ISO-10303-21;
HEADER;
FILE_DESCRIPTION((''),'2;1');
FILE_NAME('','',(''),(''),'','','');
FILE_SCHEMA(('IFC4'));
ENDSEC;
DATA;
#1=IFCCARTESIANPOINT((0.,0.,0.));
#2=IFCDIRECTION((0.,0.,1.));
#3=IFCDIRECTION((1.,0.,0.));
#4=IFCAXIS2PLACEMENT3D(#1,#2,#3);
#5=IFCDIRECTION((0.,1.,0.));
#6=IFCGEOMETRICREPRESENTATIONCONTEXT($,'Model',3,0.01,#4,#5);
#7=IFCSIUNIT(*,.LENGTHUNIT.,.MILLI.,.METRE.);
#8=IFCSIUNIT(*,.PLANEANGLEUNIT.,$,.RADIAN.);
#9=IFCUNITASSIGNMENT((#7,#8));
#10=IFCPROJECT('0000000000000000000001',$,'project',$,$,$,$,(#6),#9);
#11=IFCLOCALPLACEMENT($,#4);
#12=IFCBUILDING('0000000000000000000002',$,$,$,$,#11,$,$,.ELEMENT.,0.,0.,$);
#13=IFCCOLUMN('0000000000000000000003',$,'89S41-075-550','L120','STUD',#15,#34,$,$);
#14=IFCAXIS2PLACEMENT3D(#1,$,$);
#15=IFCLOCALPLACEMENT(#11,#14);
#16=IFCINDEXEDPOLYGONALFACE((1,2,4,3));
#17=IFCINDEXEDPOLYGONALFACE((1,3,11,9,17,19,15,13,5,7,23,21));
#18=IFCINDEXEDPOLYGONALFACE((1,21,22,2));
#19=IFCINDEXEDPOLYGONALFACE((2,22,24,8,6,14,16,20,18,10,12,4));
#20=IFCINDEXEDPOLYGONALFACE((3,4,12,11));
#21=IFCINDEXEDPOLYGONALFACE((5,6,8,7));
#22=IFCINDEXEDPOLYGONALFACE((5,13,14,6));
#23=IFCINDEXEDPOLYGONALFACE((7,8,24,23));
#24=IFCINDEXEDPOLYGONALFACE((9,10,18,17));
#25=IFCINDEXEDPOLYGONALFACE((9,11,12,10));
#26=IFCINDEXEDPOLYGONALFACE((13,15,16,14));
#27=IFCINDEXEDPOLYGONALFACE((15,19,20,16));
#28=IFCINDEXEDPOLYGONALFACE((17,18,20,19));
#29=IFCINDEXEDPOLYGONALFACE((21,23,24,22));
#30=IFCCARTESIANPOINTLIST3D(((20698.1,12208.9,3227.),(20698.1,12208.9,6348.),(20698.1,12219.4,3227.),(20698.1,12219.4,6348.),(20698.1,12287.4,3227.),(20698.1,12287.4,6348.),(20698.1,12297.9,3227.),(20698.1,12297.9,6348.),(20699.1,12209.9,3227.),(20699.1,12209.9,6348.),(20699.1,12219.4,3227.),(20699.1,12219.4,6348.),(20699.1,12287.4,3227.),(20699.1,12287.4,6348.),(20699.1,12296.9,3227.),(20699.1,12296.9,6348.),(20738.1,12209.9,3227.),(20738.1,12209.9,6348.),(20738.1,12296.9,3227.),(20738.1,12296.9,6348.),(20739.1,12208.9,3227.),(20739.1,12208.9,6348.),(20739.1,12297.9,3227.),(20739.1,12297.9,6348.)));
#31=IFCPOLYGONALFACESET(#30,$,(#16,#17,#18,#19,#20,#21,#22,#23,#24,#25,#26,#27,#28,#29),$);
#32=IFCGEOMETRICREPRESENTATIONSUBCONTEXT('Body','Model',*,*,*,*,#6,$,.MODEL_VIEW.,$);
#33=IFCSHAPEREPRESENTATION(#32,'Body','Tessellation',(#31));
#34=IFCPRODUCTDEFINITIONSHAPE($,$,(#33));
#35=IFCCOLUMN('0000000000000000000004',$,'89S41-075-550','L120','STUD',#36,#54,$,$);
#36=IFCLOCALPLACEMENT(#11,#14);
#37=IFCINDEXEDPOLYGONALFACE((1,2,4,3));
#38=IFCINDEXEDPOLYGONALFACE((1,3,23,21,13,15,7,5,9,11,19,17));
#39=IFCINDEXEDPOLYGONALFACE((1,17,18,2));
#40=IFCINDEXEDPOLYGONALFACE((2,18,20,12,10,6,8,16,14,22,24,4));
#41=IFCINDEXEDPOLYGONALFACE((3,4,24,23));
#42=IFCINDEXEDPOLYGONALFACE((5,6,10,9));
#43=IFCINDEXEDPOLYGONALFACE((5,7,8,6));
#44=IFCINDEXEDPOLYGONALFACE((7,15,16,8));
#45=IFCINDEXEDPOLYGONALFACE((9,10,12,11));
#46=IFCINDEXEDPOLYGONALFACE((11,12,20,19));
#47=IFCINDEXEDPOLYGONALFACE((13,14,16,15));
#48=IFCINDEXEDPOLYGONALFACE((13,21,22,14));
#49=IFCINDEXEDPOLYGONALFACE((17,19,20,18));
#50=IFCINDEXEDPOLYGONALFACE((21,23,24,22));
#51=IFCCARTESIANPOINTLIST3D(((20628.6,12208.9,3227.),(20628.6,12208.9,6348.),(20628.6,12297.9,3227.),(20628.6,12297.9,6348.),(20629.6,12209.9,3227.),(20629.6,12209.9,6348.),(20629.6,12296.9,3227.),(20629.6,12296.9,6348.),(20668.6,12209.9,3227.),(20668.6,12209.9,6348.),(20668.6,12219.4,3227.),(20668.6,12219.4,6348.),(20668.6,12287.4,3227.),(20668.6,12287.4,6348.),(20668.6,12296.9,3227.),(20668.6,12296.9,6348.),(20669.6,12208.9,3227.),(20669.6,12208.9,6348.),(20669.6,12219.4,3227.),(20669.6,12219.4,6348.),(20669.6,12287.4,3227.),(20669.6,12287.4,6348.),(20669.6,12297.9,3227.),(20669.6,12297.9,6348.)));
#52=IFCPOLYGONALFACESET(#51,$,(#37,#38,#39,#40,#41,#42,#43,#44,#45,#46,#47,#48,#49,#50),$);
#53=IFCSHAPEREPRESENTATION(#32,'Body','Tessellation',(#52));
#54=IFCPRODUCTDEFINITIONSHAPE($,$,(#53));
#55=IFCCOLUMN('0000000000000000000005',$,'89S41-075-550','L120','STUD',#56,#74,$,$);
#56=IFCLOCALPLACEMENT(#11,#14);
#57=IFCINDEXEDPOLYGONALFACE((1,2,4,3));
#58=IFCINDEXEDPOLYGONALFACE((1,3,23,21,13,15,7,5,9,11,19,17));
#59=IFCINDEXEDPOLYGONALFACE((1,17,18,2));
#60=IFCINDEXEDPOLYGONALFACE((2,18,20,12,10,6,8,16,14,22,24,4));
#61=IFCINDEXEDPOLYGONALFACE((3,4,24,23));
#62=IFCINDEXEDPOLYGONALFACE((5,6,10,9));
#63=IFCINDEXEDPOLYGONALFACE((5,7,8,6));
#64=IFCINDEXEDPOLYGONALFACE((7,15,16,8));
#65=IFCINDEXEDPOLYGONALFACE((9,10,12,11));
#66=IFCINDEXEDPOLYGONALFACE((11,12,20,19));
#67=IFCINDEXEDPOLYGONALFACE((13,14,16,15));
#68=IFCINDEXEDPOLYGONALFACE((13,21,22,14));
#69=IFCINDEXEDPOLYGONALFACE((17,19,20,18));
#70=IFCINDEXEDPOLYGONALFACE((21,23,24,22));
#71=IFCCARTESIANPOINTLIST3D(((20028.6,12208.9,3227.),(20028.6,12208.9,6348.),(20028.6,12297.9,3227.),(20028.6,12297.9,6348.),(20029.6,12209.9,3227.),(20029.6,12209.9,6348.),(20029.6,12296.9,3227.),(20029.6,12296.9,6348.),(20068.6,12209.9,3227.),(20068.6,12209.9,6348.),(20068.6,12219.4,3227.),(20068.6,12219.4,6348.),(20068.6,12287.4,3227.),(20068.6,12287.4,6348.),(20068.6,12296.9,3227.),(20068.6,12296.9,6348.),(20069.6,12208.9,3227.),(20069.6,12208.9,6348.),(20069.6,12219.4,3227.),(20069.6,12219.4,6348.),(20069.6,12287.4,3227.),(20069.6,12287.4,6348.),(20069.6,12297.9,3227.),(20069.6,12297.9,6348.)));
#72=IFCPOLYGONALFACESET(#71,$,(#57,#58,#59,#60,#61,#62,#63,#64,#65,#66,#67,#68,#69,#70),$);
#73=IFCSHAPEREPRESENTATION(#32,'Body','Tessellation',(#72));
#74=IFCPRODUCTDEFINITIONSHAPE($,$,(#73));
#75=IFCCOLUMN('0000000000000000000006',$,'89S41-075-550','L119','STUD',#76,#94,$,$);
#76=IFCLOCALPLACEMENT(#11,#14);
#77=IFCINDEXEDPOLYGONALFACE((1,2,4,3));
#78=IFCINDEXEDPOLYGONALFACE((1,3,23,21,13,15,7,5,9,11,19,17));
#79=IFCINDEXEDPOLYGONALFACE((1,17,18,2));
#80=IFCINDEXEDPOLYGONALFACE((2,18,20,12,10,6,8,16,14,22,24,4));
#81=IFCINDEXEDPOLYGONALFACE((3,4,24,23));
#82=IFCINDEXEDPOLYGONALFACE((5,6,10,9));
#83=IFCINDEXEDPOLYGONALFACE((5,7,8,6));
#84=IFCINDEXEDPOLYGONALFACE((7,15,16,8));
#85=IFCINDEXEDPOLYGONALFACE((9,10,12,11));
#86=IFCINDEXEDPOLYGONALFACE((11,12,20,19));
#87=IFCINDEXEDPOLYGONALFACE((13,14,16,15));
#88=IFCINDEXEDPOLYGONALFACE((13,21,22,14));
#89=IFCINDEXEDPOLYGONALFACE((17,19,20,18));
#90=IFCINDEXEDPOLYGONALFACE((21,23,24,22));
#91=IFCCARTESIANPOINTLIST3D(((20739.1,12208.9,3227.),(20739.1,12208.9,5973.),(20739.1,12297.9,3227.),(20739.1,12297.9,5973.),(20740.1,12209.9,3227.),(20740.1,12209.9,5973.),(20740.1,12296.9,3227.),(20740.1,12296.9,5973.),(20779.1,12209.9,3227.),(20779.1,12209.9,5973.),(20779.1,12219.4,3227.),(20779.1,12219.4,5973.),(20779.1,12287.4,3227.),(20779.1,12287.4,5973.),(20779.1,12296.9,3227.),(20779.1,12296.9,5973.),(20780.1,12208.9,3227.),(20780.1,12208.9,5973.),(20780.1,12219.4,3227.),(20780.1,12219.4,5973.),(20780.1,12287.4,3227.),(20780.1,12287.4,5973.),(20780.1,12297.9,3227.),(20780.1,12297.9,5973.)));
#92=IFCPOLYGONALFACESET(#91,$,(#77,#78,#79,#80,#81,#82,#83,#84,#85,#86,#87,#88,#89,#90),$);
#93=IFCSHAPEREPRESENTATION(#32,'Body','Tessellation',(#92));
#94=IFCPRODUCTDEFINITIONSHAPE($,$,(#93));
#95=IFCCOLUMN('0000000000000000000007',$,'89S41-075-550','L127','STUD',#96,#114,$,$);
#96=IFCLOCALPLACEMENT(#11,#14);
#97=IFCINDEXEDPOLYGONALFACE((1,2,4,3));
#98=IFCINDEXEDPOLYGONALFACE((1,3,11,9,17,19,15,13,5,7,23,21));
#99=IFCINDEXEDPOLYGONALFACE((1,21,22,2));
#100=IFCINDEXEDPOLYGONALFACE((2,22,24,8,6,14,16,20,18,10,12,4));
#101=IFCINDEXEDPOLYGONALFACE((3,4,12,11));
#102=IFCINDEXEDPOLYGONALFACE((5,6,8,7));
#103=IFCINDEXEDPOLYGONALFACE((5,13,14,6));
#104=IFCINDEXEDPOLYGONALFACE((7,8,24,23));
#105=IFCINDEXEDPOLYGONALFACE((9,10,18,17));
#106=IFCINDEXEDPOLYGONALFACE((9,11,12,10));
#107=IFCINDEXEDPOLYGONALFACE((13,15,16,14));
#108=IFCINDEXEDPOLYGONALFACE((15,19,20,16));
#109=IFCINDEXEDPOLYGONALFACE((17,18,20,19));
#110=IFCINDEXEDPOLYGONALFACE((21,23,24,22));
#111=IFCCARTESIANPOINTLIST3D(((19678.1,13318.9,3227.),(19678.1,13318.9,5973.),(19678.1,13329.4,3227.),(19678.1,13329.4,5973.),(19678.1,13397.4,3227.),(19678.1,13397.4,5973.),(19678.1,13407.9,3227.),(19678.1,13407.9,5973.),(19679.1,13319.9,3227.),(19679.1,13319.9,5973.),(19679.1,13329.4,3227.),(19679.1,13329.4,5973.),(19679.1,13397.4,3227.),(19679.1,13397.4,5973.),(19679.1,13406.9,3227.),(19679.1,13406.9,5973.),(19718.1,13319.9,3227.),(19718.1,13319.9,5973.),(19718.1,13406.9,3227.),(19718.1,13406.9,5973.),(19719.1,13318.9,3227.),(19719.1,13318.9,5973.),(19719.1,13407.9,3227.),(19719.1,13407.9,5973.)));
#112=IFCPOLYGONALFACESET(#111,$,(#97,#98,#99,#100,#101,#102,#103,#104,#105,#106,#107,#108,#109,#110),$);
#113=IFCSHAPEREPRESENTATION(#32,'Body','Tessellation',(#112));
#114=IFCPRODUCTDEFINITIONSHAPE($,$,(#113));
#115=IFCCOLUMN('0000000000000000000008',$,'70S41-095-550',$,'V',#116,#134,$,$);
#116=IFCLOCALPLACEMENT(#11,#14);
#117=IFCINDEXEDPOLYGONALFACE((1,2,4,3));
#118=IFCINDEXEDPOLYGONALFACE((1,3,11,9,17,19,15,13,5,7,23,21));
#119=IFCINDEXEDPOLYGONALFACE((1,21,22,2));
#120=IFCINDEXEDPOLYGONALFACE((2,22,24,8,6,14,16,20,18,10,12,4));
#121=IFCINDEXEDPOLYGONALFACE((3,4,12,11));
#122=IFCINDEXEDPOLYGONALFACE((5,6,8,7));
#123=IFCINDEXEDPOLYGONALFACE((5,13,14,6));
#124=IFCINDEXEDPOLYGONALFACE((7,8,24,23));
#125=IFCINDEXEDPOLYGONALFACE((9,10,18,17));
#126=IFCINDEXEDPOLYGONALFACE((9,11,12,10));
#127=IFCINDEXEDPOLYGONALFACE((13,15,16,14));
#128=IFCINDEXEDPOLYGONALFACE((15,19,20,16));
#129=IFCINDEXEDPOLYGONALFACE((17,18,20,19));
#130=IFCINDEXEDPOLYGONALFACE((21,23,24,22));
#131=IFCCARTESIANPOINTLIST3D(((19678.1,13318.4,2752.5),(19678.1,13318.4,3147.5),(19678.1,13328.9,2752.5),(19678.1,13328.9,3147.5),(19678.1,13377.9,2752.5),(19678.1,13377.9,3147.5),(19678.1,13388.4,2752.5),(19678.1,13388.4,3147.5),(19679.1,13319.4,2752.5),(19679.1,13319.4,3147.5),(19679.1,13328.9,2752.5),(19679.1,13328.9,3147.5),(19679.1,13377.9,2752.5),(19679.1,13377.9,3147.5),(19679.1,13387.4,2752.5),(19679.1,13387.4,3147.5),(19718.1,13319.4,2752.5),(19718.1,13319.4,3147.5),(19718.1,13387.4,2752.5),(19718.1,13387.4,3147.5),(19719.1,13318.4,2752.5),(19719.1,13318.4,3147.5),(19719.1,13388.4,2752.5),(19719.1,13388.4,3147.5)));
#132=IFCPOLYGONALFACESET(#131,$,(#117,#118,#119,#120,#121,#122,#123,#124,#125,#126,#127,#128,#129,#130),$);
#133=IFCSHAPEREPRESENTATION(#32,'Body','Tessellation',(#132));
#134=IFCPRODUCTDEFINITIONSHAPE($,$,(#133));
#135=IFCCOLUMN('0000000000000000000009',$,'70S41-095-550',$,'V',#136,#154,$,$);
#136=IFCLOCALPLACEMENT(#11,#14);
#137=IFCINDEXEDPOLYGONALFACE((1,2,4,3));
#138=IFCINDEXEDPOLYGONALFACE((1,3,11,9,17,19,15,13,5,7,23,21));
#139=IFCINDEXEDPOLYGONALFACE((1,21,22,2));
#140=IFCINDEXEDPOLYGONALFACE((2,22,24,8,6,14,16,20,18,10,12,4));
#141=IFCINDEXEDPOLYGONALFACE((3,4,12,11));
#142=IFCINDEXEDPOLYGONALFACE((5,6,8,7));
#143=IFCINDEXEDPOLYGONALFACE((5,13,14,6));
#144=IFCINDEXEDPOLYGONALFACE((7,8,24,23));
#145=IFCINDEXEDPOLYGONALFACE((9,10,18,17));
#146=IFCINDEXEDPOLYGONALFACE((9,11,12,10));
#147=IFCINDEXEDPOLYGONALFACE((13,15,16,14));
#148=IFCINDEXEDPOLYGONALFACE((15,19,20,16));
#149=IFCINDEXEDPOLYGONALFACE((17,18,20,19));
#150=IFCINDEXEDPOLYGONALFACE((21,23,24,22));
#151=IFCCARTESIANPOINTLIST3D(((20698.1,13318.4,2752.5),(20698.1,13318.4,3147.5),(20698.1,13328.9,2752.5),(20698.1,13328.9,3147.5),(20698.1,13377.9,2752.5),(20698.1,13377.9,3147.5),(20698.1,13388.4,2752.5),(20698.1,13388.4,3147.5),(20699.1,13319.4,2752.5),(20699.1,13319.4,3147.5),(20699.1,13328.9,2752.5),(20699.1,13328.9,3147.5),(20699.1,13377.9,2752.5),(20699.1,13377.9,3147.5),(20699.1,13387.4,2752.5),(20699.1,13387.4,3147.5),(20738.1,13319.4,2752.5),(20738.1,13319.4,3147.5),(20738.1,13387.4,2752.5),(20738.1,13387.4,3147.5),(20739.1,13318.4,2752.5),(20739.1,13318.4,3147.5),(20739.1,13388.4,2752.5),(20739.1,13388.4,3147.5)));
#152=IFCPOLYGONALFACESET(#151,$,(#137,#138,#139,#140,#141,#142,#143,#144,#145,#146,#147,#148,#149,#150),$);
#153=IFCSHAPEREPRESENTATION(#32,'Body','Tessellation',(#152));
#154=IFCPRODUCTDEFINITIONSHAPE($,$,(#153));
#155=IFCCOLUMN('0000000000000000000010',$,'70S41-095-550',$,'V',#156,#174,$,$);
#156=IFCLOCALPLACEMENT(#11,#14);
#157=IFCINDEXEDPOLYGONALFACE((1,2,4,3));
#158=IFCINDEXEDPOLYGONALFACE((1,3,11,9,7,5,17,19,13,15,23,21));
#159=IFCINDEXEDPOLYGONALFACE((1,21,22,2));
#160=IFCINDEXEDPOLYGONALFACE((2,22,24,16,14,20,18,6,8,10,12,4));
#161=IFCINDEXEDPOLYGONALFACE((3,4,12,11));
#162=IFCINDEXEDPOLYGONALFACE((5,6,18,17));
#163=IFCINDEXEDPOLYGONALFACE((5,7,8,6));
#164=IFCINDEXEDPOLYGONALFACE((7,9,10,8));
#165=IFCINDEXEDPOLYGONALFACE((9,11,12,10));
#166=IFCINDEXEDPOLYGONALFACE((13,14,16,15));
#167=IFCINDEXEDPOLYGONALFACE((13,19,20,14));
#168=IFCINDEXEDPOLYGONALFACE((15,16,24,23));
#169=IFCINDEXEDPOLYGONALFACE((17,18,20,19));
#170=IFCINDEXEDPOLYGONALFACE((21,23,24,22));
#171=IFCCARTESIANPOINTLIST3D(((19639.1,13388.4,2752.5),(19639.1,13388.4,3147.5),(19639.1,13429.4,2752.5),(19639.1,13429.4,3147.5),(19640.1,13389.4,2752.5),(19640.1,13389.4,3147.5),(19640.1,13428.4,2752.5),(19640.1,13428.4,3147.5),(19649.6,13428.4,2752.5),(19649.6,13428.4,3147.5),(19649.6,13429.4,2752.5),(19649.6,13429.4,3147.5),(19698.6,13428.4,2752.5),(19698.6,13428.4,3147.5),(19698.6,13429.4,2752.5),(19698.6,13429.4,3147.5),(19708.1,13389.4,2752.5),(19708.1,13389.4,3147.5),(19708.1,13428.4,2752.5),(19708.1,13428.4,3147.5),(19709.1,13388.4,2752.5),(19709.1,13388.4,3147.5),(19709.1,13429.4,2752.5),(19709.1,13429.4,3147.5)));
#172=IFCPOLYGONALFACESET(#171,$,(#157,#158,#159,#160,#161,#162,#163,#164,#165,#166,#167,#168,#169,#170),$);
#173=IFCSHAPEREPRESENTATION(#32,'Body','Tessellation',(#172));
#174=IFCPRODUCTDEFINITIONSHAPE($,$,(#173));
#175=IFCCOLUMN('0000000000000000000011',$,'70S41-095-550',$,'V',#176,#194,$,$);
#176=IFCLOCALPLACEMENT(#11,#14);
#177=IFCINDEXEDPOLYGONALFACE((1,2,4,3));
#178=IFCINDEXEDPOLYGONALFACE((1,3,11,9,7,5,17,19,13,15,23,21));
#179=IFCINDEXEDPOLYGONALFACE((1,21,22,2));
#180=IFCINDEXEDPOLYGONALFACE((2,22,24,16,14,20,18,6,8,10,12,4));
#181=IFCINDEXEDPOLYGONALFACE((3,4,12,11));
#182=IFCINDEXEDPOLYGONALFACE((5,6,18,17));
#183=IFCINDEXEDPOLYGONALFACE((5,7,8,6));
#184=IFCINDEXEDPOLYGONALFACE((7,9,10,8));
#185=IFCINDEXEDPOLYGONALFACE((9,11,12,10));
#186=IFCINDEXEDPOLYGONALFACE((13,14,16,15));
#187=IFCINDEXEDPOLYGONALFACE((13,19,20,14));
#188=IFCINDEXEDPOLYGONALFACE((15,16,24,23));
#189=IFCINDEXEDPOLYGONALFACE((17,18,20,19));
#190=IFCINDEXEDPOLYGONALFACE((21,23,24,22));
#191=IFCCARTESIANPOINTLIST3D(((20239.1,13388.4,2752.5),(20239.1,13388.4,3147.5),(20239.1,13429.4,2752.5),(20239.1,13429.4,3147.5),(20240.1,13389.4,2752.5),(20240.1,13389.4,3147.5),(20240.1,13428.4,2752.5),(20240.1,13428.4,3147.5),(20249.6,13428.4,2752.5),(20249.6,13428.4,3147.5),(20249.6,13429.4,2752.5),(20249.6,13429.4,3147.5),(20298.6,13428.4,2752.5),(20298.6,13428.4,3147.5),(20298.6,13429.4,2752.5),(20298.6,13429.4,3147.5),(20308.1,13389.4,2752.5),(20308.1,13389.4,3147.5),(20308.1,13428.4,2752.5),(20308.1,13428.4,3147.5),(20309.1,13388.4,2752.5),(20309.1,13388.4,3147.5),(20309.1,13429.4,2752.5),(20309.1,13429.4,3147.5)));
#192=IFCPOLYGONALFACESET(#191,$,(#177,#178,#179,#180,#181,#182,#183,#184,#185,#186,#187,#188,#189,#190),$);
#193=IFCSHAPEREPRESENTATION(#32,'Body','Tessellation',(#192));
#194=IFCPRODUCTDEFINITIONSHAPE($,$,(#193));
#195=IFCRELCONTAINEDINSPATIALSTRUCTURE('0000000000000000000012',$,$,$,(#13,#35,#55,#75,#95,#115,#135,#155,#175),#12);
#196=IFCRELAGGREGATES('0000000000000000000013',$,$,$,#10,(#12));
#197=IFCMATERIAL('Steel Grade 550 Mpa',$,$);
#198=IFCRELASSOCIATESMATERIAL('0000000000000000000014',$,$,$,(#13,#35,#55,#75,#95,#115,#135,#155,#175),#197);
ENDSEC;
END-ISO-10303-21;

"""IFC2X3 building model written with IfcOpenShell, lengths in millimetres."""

from ifc_helpers import new_model, si_unit, direction, frame, origin, origin_with_axes, origin_2d_with_axis, place, context, subcontext, project, spatial, c_section, extrude, source, transform, mapped, material, element, save


model = new_model("IFC2X3")

# Units and contexts
model_context = context("Model", 3, precision=0.01, world=origin_with_axes(), true_north=direction((0.0, 1.0, 0.0)))
body_context = subcontext(model_context, "Body", "Model", "MODEL_VIEW")
ifc_project = project(units=[si_unit("LENGTHUNIT", "METRE", prefix="MILLI"), si_unit("PLANEANGLEUNIT", "RADIAN")], contexts=[model_context])

# Building
building_placement = place(None, origin_with_axes())
building = spatial("IfcBuilding", under=ifc_project, at=building_placement, CompositionType="ELEMENT", ElevationOfRefHeight=0.0, ElevationOfTerrain=0.0)

# Columns
ifc_material = material(Name="Steel Grade 550 Mpa")
shared_shape_1 = source(origin(), body_context, "Body", "SweptSolid", [
    extrude(c_section(Depth=89.0, Width=41.0, WallThickness=1.0, Girth=10.5, at=origin_2d_with_axis()), origin_with_axes(), (0.0, 0.0, 1.0), 3121.0),
])
column_1_placement = place(None, frame((20718.6, 12253.4, 3227.0), z_axis=(0.0, 0.0, 1.0), x_axis=(-1.0, 0.0, 0.0)))
element("IfcColumn", 1, at=column_1_placement, inside=building, material=ifc_material, Name="89S41-075-550", Description="L120", ObjectType="STUD", context=body_context, shape_type="MappedRepresentation", body=[
    mapped(shared_shape_1, transform((0.0, 0.0, 0.0), scale=1.0)),
])
shared_shape_2 = source(origin(), body_context, "Body", "SweptSolid", [
    extrude(c_section(Depth=89.0, Width=41.0, WallThickness=1.0, Girth=10.5, at=origin_2d_with_axis()), origin_with_axes(), (0.0, 0.0, 1.0), 3121.0),
])
column_2_placement = place(None, frame((20649.1, 12253.4, 3227.0), z_axis=(0.0, 0.0, 1.0), x_axis=(1.0, 0.0, 0.0)))
element("IfcColumn", 2, at=column_2_placement, inside=building, material=ifc_material, Name="89S41-075-550", Description="L120", ObjectType="STUD", context=body_context, shape_type="MappedRepresentation", body=[
    mapped(shared_shape_2, transform((0.0, 0.0, 0.0), scale=1.0)),
])
shared_shape_3 = source(origin(), body_context, "Body", "SweptSolid", [
    extrude(c_section(Depth=89.0, Width=41.0, WallThickness=1.0, Girth=10.5, at=origin_2d_with_axis()), origin_with_axes(), (0.0, 0.0, 1.0), 3121.0),
])
column_3_placement = place(None, frame((20049.1, 12253.4, 3227.0), z_axis=(0.0, 0.0, 1.0), x_axis=(1.0, 0.0, 0.0)))
element("IfcColumn", 3, at=column_3_placement, inside=building, material=ifc_material, Name="89S41-075-550", Description="L120", ObjectType="STUD", context=body_context, shape_type="MappedRepresentation", body=[
    mapped(shared_shape_3, transform((0.0, 0.0, 0.0), scale=1.0)),
])
shared_shape_4 = source(origin(), body_context, "Body", "SweptSolid", [
    extrude(c_section(Depth=89.0, Width=41.0, WallThickness=1.0, Girth=10.5, at=origin_2d_with_axis()), origin_with_axes(), (0.0, 0.0, 1.0), 2746.0),
])
column_4_placement = place(None, frame((20759.6, 12253.4, 3227.0), z_axis=(0.0, 0.0, 1.0), x_axis=(1.0, 0.0, 0.0)))
element("IfcColumn", 4, at=column_4_placement, inside=building, material=ifc_material, Name="89S41-075-550", Description="L119", ObjectType="STUD", context=body_context, shape_type="MappedRepresentation", body=[
    mapped(shared_shape_4, transform((0.0, 0.0, 0.0), scale=1.0)),
])
shared_shape_5 = source(origin(), body_context, "Body", "SweptSolid", [
    extrude(c_section(Depth=89.0, Width=41.0, WallThickness=1.0, Girth=10.5, at=origin_2d_with_axis()), origin_with_axes(), (0.0, 0.0, 1.0), 2746.0),
])
column_5_placement = place(None, frame((19698.6, 13363.4, 3227.0), z_axis=(0.0, 0.0, 1.0), x_axis=(-1.0, 0.0, 0.0)))
element("IfcColumn", 5, at=column_5_placement, inside=building, material=ifc_material, Name="89S41-075-550", Description="L127", ObjectType="STUD", context=body_context, shape_type="MappedRepresentation", body=[
    mapped(shared_shape_5, transform((0.0, 0.0, 0.0), scale=1.0)),
])
shared_shape_6 = source(origin(), body_context, "Body", "SweptSolid", [
    extrude(c_section(Depth=70.0, Width=41.0, WallThickness=1.0, Girth=10.5, at=origin_2d_with_axis()), origin_with_axes(), (0.0, 0.0, 1.0), 395.0),
])
column_6_placement = place(None, frame((19698.6, 13353.4, 3147.5), z_axis=(0.0, 0.0, -1.0), x_axis=(-1.0, 0.0, 0.0)))
element("IfcColumn", 6, at=column_6_placement, inside=building, material=ifc_material, Name="70S41-095-550", ObjectType="V", context=body_context, shape_type="MappedRepresentation", body=[
    mapped(shared_shape_6, transform((0.0, 0.0, 0.0), scale=1.0)),
])
shared_shape_7 = source(origin(), body_context, "Body", "SweptSolid", [
    extrude(c_section(Depth=70.0, Width=41.0, WallThickness=1.0, Girth=10.5, at=origin_2d_with_axis()), origin_with_axes(), (0.0, 0.0, 1.0), 395.0),
])
column_7_placement = place(None, frame((20718.6, 13353.4, 3147.5), z_axis=(0.0, 0.0, -1.0), x_axis=(-1.0, 0.0, 0.0)))
element("IfcColumn", 7, at=column_7_placement, inside=building, material=ifc_material, Name="70S41-095-550", ObjectType="V", context=body_context, shape_type="MappedRepresentation", body=[
    mapped(shared_shape_7, transform((0.0, 0.0, 0.0), scale=1.0)),
])
shared_shape_8 = source(origin(), body_context, "Body", "SweptSolid", [
    extrude(c_section(Depth=70.0, Width=41.0, WallThickness=1.0, Girth=10.5, at=origin_2d_with_axis()), origin_with_axes(), (0.0, 0.0, 1.0), 395.0),
])
column_8_placement = place(None, frame((19674.1, 13408.9, 3147.5), z_axis=(0.0, 0.0, -1.0), x_axis=(0.0, 1.0, 0.0)))
element("IfcColumn", 8, at=column_8_placement, inside=building, material=ifc_material, Name="70S41-095-550", ObjectType="V", context=body_context, shape_type="MappedRepresentation", body=[
    mapped(shared_shape_8, transform((0.0, 0.0, 0.0), scale=1.0)),
])
shared_shape_9 = source(origin(), body_context, "Body", "SweptSolid", [
    extrude(c_section(Depth=70.0, Width=41.0, WallThickness=1.0, Girth=10.5, at=origin_2d_with_axis()), origin_with_axes(), (0.0, 0.0, 1.0), 395.0),
])
column_9_placement = place(None, frame((20274.1, 13408.9, 3147.5), z_axis=(0.0, 0.0, -1.0), x_axis=(0.0, 1.0, 0.0)))
element("IfcColumn", 9, at=column_9_placement, inside=building, material=ifc_material, Name="70S41-095-550", ObjectType="V", context=body_context, shape_type="MappedRepresentation", body=[
    mapped(shared_shape_9, transform((0.0, 0.0, 0.0), scale=1.0)),
])

save(model, "model.ifc")
